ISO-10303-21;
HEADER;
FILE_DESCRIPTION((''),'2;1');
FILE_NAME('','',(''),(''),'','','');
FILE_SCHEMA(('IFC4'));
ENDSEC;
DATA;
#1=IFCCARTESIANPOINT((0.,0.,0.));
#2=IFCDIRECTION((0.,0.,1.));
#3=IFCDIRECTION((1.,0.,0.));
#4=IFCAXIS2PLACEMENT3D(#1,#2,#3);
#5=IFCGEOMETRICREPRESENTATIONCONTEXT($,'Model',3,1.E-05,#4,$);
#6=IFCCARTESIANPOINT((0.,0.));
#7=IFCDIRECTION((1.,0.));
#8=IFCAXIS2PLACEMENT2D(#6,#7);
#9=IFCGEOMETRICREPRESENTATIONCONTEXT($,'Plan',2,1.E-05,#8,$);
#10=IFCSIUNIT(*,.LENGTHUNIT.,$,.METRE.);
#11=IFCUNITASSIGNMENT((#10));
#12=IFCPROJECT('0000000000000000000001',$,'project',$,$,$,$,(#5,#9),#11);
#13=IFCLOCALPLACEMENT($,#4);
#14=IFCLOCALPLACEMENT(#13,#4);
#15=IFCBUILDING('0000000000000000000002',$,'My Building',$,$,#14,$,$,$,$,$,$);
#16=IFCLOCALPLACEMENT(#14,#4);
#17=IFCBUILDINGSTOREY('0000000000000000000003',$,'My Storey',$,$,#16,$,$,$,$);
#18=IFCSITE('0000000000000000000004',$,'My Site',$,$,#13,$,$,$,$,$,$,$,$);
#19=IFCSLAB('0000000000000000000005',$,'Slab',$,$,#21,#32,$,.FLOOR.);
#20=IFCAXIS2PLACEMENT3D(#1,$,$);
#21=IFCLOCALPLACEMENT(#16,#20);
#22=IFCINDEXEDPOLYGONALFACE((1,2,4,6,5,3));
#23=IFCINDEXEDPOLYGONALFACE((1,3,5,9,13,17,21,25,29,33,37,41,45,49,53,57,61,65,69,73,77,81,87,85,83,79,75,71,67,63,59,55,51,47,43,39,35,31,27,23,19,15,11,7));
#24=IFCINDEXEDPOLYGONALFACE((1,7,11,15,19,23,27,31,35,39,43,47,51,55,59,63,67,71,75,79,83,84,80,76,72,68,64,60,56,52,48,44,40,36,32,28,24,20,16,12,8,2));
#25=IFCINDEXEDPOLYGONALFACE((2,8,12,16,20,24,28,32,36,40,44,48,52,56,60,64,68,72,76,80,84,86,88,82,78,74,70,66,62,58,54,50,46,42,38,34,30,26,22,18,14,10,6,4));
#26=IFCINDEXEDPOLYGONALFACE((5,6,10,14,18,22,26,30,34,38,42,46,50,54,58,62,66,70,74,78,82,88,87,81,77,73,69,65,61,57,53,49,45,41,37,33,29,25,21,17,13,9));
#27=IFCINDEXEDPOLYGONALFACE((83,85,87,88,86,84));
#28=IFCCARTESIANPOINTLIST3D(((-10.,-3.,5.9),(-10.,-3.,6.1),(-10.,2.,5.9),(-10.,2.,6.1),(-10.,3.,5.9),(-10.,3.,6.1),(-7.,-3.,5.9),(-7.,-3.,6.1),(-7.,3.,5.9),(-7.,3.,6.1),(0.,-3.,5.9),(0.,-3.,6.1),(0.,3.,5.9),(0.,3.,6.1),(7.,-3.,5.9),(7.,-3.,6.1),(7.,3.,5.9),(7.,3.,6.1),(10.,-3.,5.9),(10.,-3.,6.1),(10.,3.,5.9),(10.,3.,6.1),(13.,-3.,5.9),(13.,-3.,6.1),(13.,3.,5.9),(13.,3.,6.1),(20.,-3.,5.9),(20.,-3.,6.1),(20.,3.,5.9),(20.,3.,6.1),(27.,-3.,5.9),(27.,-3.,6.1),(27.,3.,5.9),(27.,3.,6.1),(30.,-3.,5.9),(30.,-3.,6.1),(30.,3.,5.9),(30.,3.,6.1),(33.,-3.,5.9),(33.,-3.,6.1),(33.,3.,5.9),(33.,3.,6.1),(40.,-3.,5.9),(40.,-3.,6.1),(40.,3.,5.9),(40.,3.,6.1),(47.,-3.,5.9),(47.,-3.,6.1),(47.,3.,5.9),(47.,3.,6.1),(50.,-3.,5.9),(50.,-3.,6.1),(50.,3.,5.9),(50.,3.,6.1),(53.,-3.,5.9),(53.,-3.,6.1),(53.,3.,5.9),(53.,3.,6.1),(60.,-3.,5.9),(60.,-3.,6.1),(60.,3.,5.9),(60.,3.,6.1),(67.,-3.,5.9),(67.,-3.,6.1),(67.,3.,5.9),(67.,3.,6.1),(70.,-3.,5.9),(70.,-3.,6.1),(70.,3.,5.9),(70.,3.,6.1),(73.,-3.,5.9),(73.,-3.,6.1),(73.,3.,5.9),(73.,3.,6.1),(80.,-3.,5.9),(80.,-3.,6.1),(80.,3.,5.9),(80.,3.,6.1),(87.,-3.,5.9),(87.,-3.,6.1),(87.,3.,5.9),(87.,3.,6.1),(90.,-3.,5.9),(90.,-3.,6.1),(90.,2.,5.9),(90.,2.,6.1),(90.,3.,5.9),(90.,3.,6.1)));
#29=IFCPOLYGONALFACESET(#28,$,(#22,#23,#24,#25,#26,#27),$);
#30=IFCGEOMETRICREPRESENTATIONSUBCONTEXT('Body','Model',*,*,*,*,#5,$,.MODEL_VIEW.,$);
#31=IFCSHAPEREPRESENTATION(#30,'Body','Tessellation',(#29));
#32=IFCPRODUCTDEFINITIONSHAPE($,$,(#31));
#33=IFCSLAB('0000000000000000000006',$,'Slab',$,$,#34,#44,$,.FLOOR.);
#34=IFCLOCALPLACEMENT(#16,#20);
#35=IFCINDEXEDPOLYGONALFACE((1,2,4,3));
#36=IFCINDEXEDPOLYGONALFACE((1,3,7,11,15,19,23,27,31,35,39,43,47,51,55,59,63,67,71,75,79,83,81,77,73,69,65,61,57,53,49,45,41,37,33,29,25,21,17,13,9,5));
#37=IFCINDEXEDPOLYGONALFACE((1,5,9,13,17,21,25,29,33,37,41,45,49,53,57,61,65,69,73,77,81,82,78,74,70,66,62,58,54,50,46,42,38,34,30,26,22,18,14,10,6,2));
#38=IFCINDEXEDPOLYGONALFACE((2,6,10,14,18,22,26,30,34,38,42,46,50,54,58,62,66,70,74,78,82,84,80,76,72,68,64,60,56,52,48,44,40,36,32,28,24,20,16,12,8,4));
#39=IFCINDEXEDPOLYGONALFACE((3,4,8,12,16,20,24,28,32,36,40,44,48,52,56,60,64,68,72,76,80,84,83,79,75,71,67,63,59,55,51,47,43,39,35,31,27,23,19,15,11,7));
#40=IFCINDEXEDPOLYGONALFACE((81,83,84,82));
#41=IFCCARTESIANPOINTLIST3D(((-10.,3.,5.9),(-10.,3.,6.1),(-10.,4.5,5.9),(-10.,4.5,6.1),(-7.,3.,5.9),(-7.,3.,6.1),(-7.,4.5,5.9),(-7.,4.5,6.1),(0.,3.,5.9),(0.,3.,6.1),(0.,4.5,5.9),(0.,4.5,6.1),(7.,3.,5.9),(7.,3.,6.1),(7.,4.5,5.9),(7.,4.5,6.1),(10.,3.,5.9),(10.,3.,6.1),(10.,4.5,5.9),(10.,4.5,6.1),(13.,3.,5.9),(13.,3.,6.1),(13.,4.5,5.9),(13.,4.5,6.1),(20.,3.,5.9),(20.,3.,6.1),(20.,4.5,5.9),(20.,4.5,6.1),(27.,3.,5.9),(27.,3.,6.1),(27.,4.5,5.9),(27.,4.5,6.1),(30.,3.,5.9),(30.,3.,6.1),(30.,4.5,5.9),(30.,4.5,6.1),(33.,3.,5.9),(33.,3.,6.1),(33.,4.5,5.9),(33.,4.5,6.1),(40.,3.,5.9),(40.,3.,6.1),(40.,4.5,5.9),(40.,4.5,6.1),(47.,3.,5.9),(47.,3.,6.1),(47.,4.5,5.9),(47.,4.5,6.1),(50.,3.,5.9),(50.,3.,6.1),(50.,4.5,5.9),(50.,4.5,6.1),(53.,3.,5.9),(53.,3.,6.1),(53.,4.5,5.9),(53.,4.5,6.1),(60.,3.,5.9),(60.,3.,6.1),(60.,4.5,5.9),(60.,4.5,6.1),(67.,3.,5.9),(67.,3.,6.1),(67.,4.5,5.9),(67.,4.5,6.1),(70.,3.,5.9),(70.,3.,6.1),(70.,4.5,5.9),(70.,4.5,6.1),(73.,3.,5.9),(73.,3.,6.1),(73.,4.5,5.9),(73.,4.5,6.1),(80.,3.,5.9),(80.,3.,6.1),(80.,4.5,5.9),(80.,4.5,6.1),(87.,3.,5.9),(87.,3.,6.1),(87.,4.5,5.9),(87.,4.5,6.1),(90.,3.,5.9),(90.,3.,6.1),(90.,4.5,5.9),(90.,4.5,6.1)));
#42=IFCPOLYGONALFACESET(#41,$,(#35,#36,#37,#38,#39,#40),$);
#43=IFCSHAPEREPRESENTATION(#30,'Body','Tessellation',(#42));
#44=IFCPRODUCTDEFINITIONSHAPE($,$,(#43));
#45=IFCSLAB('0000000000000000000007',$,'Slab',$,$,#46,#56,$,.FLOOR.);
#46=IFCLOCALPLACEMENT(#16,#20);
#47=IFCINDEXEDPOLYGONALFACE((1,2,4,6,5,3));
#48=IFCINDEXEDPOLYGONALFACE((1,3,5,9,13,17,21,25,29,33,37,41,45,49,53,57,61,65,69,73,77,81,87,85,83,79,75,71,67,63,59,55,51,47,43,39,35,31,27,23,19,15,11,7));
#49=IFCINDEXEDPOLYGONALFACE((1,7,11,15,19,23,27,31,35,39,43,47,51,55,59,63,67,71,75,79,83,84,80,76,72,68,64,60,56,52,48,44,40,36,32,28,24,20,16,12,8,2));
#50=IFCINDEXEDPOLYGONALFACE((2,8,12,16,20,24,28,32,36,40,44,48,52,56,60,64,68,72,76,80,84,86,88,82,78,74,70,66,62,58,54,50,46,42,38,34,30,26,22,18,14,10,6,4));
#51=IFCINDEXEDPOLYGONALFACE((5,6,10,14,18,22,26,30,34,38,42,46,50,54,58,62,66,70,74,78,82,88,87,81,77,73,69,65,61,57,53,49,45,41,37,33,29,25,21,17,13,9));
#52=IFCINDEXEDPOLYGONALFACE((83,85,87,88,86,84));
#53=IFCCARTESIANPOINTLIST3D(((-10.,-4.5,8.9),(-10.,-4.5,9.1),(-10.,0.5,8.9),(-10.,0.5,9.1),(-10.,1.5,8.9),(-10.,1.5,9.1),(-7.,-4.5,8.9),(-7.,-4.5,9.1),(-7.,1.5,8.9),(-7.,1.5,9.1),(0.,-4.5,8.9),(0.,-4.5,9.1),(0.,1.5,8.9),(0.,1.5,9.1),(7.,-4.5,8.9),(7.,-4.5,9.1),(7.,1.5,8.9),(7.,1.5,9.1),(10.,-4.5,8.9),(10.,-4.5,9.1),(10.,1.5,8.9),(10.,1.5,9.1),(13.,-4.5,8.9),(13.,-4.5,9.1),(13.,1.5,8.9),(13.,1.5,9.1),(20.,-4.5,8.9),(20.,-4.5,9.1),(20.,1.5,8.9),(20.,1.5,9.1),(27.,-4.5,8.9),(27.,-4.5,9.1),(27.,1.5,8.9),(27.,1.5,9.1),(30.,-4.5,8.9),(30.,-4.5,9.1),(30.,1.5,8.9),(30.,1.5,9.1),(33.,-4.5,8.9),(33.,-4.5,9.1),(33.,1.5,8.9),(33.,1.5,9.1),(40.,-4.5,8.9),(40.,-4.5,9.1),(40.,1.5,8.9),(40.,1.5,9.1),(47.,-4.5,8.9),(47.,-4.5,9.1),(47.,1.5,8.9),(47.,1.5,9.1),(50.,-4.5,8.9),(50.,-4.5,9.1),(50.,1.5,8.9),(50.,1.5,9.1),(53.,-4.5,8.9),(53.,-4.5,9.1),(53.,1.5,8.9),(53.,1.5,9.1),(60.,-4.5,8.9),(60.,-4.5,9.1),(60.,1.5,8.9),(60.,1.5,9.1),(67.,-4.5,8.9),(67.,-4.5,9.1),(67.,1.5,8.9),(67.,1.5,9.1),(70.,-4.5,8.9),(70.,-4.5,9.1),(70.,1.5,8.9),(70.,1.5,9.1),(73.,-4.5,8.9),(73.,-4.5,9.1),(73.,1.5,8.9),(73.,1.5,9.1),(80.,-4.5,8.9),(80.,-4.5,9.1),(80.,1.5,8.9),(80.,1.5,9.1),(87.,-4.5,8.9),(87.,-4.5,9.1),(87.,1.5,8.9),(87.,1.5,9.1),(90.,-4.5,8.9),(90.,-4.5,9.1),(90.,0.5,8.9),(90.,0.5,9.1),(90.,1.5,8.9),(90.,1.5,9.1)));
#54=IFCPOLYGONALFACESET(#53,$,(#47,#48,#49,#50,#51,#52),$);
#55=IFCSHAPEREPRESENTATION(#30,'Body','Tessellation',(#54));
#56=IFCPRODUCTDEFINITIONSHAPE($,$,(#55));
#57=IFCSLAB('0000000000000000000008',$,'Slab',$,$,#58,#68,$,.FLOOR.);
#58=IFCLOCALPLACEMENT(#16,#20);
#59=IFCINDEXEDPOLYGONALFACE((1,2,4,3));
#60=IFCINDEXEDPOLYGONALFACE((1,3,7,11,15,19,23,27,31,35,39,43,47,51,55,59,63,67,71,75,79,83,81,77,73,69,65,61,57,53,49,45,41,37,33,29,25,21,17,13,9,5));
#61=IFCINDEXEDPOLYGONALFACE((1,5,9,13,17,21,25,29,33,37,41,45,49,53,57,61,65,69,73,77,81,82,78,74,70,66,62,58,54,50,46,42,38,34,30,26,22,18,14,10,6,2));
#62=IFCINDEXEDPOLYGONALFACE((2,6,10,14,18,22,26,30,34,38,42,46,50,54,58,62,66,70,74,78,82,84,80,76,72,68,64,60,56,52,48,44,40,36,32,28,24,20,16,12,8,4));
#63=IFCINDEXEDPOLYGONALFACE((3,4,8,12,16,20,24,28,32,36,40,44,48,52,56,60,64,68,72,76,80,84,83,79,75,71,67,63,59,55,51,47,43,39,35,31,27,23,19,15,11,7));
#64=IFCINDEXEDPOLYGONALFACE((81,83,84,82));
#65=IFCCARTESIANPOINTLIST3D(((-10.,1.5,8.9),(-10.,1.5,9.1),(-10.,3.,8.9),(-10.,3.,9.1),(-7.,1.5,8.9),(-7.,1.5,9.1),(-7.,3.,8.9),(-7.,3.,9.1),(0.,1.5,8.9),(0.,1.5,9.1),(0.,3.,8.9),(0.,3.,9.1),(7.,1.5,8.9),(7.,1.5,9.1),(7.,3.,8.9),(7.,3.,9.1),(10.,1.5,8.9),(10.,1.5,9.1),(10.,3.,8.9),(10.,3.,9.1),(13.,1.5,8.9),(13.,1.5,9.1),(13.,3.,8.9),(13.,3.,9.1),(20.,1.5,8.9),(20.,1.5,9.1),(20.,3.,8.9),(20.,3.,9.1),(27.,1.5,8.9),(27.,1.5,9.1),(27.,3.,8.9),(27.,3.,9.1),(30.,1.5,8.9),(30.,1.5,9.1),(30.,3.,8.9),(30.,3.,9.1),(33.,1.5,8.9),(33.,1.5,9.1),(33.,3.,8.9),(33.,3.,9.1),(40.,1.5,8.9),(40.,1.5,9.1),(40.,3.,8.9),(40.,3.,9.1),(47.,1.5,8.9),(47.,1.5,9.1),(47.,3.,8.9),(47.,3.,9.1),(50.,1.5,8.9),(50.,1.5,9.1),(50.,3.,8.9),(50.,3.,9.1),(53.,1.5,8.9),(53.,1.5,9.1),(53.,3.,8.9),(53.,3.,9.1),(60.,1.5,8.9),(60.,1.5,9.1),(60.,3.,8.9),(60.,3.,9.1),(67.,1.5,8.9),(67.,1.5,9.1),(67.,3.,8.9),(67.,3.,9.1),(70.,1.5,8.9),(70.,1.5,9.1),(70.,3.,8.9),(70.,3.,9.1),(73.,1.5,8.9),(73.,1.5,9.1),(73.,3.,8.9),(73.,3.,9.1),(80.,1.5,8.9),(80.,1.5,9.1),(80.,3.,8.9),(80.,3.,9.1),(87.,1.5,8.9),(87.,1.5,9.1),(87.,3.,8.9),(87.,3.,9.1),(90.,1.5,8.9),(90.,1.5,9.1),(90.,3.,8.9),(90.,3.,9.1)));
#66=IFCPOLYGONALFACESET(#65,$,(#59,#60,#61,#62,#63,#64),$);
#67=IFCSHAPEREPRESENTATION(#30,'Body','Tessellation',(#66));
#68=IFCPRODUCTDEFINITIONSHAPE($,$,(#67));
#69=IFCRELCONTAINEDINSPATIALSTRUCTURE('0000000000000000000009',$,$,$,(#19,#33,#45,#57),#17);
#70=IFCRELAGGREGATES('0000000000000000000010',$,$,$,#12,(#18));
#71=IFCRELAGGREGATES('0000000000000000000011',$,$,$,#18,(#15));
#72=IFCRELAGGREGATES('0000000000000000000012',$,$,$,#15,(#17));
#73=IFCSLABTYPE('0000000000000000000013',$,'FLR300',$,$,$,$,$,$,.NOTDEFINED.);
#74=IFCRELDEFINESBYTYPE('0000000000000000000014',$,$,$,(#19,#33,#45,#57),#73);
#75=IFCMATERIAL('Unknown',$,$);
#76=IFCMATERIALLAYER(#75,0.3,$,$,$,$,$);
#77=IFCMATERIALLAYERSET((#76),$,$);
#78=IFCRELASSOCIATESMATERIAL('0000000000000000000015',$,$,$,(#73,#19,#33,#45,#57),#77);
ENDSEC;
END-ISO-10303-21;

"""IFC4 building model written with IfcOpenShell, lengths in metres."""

from ifc_helpers import new_model, si_unit, frame, origin, origin_with_axes, origin_2d_with_axis, place, context, subcontext, project, spatial, polyline, outline, extrude, material, layer, layer_set, layer_usage, type_object, element, save


model = new_model("IFC4")

# Units and contexts
model_context = context("Model", 3, precision=1e-05, world=origin_with_axes())
plan_context = context("Plan", 2, precision=1e-05, world=origin_2d_with_axis())
body_context = subcontext(model_context, "Body", "Model", "MODEL_VIEW")
ifc_project = project(units=[si_unit("LENGTHUNIT", "METRE")], contexts=[model_context, plan_context])

# Site, building, storey
site_placement = place(None, origin_with_axes())
site = spatial("IfcSite", under=ifc_project, at=site_placement, Name="My Site")
building_placement = place(site_placement, origin_with_axes())
building = spatial("IfcBuilding", under=site, at=building_placement, Name="My Building")
storey_placement = place(building_placement, origin_with_axes())
storey = spatial("IfcBuildingStorey", under=building, at=storey_placement, Name="My Storey")

# Slabs
ifc_material = material(Name="Unknown")
ifc_layer_1 = layer(ifc_material, 0.3)
ifc_layer_set_1 = layer_set([ifc_layer_1])
slab_type = type_object("IfcSlabType", Name="FLR300", PredefinedType="NOTDEFINED", material=ifc_layer_set_1)
ifc_layer_usage_1 = layer_usage(ifc_layer_set_1, "AXIS3", "POSITIVE", 0.0)
slab_1_placement = place(storey_placement, frame((40.0, 0.0909, 5.9), z_axis=(0.0, 0.0, 1.0), x_axis=(1.0, 0.0, 0.0)))
element("IfcSlab", 1, at=slab_1_placement, inside=storey, type_object=slab_type, material=ifc_layer_usage_1, Name="Slab", PredefinedType="FLOOR", context=body_context, shape_type="SweptSolid", body=[
    extrude(outline(polyline([(-47.0, 2.9091), (-50.0, 2.9091), (-50.0, 1.9091), (-50.0, -3.0909), (-47.0, -3.0909), (-40.0, -3.0909), (-33.0, -3.0909), (-30.0, -3.0909), (-27.0, -3.0909), (-20.0, -3.0909), (-13.0, -3.0909), (-10.0, -3.0909), (-7.0, -3.0909), (0.0, -3.0909), (7.0, -3.0909), (10.0, -3.0909), (13.0, -3.0909), (20.0, -3.0909), (27.0, -3.0909), (30.0, -3.0909), (33.0, -3.0909), (40.0, -3.0909), (47.0, -3.0909), (50.0, -3.0909), (50.0, 1.9091), (50.0, 2.9091), (47.0, 2.9091), (40.0, 2.9091), (33.0, 2.9091), (30.0, 2.9091), (27.0, 2.9091), (20.0, 2.9091), (13.0, 2.9091), (10.0, 2.9091), (7.0, 2.9091), (0.0, 2.9091), (-7.0, 2.9091), (-10.0, 2.9091), (-13.0, 2.9091), (-20.0, 2.9091), (-27.0, 2.9091), (-30.0, 2.9091), (-33.0, 2.9091), (-40.0, 2.9091), (-47.0, 2.9091)])), origin(), (0.0, 0.0, 1.0), 0.2),
])
ifc_layer_usage_2 = layer_usage(ifc_layer_set_1, "AXIS3", "POSITIVE", 0.0)
slab_2_placement = place(storey_placement, frame((40.0, 3.75, 5.9), z_axis=(0.0, 0.0, 1.0), x_axis=(1.0, 0.0, 0.0)))
element("IfcSlab", 2, at=slab_2_placement, inside=storey, type_object=slab_type, material=ifc_layer_usage_2, Name="Slab", PredefinedType="FLOOR", context=body_context, shape_type="SweptSolid", body=[
    extrude(outline(polyline([(-40.0, -0.75), (-33.0, -0.75), (-30.0, -0.75), (-27.0, -0.75), (-20.0, -0.75), (-13.0, -0.75), (-10.0, -0.75), (-7.0, -0.75), (0.0, -0.75), (7.0, -0.75), (10.0, -0.75), (13.0, -0.75), (20.0, -0.75), (27.0, -0.75), (30.0, -0.75), (33.0, -0.75), (40.0, -0.75), (47.0, -0.75), (50.0, -0.75), (50.0, 0.75), (47.0, 0.75), (40.0, 0.75), (33.0, 0.75), (30.0, 0.75), (27.0, 0.75), (20.0, 0.75), (13.0, 0.75), (10.0, 0.75), (7.0, 0.75), (0.0, 0.75), (-7.0, 0.75), (-10.0, 0.75), (-13.0, 0.75), (-20.0, 0.75), (-27.0, 0.75), (-30.0, 0.75), (-33.0, 0.75), (-40.0, 0.75), (-47.0, 0.75), (-50.0, 0.75), (-50.0, -0.75), (-47.0, -0.75), (-40.0, -0.75)])), origin(), (0.0, 0.0, 1.0), 0.2),
])
ifc_layer_usage_3 = layer_usage(ifc_layer_set_1, "AXIS3", "POSITIVE", 0.0)
slab_3_placement = place(storey_placement, frame((40.0, -1.4091, 8.9), z_axis=(0.0, 0.0, 1.0), x_axis=(1.0, 0.0, 0.0)))
element("IfcSlab", 3, at=slab_3_placement, inside=storey, type_object=slab_type, material=ifc_layer_usage_3, Name="Slab", PredefinedType="FLOOR", context=body_context, shape_type="SweptSolid", body=[
    extrude(outline(polyline([(-47.0, 2.9091), (-50.0, 2.9091), (-50.0, 1.9091), (-50.0, -3.0909), (-47.0, -3.0909), (-40.0, -3.0909), (-33.0, -3.0909), (-30.0, -3.0909), (-27.0, -3.0909), (-20.0, -3.0909), (-13.0, -3.0909), (-10.0, -3.0909), (-7.0, -3.0909), (0.0, -3.0909), (7.0, -3.0909), (10.0, -3.0909), (13.0, -3.0909), (20.0, -3.0909), (27.0, -3.0909), (30.0, -3.0909), (33.0, -3.0909), (40.0, -3.0909), (47.0, -3.0909), (50.0, -3.0909), (50.0, 1.9091), (50.0, 2.9091), (47.0, 2.9091), (40.0, 2.9091), (33.0, 2.9091), (30.0, 2.9091), (27.0, 2.9091), (20.0, 2.9091), (13.0, 2.9091), (10.0, 2.9091), (7.0, 2.9091), (0.0, 2.9091), (-7.0, 2.9091), (-10.0, 2.9091), (-13.0, 2.9091), (-20.0, 2.9091), (-27.0, 2.9091), (-30.0, 2.9091), (-33.0, 2.9091), (-40.0, 2.9091), (-47.0, 2.9091)])), origin(), (0.0, 0.0, 1.0), 0.2),
])
ifc_layer_usage_4 = layer_usage(ifc_layer_set_1, "AXIS3", "POSITIVE", 0.0)
slab_4_placement = place(storey_placement, frame((40.0, 2.25, 8.9), z_axis=(0.0, 0.0, 1.0), x_axis=(1.0, 0.0, 0.0)))
element("IfcSlab", 4, at=slab_4_placement, inside=storey, type_object=slab_type, material=ifc_layer_usage_4, Name="Slab", PredefinedType="FLOOR", context=body_context, shape_type="SweptSolid", body=[
    extrude(outline(polyline([(-40.0, -0.75), (-33.0, -0.75), (-30.0, -0.75), (-27.0, -0.75), (-20.0, -0.75), (-13.0, -0.75), (-10.0, -0.75), (-7.0, -0.75), (0.0, -0.75), (7.0, -0.75), (10.0, -0.75), (13.0, -0.75), (20.0, -0.75), (27.0, -0.75), (30.0, -0.75), (33.0, -0.75), (40.0, -0.75), (47.0, -0.75), (50.0, -0.75), (50.0, 0.75), (47.0, 0.75), (40.0, 0.75), (33.0, 0.75), (30.0, 0.75), (27.0, 0.75), (20.0, 0.75), (13.0, 0.75), (10.0, 0.75), (7.0, 0.75), (0.0, 0.75), (-7.0, 0.75), (-10.0, 0.75), (-13.0, 0.75), (-20.0, 0.75), (-27.0, 0.75), (-30.0, 0.75), (-33.0, 0.75), (-40.0, 0.75), (-47.0, 0.75), (-50.0, 0.75), (-50.0, -0.75), (-47.0, -0.75), (-40.0, -0.75)])), origin(), (0.0, 0.0, 1.0), 0.2),
])

save(model, "model.ifc")
